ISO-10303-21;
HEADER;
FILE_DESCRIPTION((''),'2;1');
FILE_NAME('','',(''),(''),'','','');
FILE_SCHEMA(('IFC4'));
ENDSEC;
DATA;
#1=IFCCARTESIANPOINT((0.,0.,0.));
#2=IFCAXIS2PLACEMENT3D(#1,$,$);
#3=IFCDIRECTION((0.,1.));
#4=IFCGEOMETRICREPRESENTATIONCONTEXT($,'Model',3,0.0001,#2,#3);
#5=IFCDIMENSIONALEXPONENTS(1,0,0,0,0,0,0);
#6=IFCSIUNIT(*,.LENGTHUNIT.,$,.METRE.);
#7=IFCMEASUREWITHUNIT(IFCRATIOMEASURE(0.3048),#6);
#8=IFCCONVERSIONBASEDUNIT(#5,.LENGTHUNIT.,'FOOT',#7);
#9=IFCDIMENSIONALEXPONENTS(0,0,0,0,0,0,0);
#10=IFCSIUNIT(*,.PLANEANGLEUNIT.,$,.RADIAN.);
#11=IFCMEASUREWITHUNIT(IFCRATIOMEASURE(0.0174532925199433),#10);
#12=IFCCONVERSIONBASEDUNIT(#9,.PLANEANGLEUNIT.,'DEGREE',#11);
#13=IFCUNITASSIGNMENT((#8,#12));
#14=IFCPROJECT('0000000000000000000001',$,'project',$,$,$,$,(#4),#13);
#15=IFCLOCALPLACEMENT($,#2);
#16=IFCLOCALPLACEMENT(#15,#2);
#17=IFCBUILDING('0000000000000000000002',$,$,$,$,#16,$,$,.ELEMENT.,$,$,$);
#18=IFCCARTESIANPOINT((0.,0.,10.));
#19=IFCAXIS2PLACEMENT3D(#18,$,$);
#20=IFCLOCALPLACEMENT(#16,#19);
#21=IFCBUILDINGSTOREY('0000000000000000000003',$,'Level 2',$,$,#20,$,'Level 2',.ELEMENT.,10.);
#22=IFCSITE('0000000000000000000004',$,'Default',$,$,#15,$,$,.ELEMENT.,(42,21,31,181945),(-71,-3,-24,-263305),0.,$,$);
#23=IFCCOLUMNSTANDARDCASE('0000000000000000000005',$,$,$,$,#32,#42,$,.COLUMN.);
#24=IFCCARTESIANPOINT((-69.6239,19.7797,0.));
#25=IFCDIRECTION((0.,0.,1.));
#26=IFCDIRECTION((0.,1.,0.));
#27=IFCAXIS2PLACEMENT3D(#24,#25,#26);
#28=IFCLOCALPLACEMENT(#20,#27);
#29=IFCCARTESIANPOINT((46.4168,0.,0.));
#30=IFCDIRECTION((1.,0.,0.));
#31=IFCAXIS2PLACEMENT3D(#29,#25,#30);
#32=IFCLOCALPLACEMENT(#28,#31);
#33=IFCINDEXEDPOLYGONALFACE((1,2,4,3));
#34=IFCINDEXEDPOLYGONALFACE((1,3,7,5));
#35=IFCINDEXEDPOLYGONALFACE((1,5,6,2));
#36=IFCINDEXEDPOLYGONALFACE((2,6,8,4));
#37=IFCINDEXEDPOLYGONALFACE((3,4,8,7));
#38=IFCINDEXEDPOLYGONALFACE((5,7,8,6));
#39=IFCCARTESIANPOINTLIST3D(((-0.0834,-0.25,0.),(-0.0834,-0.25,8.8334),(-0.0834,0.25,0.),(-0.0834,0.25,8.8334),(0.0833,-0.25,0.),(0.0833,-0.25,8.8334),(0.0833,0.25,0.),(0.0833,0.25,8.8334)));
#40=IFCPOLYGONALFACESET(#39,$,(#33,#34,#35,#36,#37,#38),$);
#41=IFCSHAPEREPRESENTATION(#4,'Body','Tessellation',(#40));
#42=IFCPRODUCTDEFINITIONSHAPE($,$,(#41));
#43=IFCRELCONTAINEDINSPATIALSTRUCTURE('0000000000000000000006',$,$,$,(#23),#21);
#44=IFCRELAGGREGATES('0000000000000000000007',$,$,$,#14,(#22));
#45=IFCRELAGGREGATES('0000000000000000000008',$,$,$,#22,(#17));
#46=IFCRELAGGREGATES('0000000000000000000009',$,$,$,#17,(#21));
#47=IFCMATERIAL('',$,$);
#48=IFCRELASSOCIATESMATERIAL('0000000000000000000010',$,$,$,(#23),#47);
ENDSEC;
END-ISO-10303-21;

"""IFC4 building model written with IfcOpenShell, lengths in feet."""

from ifc_helpers import new_model, entity, si_unit, converted_unit, direction, frame, origin, place, context, project, spatial, rectangle, extrude, material, element, save


model = new_model("IFC4")

# Units and contexts
model_context = context("Model", 3, precision=0.0001, world=origin(), true_north=direction((0.0, 1.0)))
ifc_project = project(units=[converted_unit("LENGTHUNIT", "FOOT", entity("IfcRatioMeasure", 0.3048), si_unit("LENGTHUNIT", "METRE"), dimensions=[1, 0, 0, 0, 0, 0, 0]), converted_unit("PLANEANGLEUNIT", "DEGREE", entity("IfcRatioMeasure", 0.0174532925199433), si_unit("PLANEANGLEUNIT", "RADIAN"), dimensions=[0, 0, 0, 0, 0, 0, 0])], contexts=[model_context])

# Site, building, storey
site_placement = place(None, origin())
site = spatial("IfcSite", under=ifc_project, at=site_placement, Name="Default", CompositionType="ELEMENT", RefLatitude=(42, 21, 31, 181945), RefLongitude=(-71, -3, -24, -263305), RefElevation=0.0)
building_placement = place(site_placement, origin())
building = spatial("IfcBuilding", under=site, at=building_placement, CompositionType="ELEMENT")
storey_placement = place(building_placement, frame((0.0, 0.0, 10.0)))
storey = spatial("IfcBuildingStorey", under=building, at=storey_placement, Name="Level 2", LongName="Level 2", CompositionType="ELEMENT", Elevation=10.0)

# Column
ifc_material_1 = material(Name="")
placement_1 = place(storey_placement, frame((-69.6239, 19.7797, 0.0), z_axis=(0.0, 0.0, 1.0), x_axis=(0.0, 1.0, 0.0)))
for number, where, z_axis, x_axis in (
    (1, (46.4168, 0.0, 0.0), (0.0, 0.0, 1.0), (1.0, 0.0, 0.0)),
):
    element("IfcColumnStandardCase", number, at=place(placement_1, frame(where, z_axis=z_axis, x_axis=x_axis)), inside=storey, material=ifc_material_1, PredefinedType="COLUMN", context=model_context, shape_type="SweptSolid", body=[
        extrude(rectangle(XDim=0.1667, YDim=0.5), origin(), (0.0, 0.0, 1.0), 8.8334),
    ])

save(model, "model.ifc")
